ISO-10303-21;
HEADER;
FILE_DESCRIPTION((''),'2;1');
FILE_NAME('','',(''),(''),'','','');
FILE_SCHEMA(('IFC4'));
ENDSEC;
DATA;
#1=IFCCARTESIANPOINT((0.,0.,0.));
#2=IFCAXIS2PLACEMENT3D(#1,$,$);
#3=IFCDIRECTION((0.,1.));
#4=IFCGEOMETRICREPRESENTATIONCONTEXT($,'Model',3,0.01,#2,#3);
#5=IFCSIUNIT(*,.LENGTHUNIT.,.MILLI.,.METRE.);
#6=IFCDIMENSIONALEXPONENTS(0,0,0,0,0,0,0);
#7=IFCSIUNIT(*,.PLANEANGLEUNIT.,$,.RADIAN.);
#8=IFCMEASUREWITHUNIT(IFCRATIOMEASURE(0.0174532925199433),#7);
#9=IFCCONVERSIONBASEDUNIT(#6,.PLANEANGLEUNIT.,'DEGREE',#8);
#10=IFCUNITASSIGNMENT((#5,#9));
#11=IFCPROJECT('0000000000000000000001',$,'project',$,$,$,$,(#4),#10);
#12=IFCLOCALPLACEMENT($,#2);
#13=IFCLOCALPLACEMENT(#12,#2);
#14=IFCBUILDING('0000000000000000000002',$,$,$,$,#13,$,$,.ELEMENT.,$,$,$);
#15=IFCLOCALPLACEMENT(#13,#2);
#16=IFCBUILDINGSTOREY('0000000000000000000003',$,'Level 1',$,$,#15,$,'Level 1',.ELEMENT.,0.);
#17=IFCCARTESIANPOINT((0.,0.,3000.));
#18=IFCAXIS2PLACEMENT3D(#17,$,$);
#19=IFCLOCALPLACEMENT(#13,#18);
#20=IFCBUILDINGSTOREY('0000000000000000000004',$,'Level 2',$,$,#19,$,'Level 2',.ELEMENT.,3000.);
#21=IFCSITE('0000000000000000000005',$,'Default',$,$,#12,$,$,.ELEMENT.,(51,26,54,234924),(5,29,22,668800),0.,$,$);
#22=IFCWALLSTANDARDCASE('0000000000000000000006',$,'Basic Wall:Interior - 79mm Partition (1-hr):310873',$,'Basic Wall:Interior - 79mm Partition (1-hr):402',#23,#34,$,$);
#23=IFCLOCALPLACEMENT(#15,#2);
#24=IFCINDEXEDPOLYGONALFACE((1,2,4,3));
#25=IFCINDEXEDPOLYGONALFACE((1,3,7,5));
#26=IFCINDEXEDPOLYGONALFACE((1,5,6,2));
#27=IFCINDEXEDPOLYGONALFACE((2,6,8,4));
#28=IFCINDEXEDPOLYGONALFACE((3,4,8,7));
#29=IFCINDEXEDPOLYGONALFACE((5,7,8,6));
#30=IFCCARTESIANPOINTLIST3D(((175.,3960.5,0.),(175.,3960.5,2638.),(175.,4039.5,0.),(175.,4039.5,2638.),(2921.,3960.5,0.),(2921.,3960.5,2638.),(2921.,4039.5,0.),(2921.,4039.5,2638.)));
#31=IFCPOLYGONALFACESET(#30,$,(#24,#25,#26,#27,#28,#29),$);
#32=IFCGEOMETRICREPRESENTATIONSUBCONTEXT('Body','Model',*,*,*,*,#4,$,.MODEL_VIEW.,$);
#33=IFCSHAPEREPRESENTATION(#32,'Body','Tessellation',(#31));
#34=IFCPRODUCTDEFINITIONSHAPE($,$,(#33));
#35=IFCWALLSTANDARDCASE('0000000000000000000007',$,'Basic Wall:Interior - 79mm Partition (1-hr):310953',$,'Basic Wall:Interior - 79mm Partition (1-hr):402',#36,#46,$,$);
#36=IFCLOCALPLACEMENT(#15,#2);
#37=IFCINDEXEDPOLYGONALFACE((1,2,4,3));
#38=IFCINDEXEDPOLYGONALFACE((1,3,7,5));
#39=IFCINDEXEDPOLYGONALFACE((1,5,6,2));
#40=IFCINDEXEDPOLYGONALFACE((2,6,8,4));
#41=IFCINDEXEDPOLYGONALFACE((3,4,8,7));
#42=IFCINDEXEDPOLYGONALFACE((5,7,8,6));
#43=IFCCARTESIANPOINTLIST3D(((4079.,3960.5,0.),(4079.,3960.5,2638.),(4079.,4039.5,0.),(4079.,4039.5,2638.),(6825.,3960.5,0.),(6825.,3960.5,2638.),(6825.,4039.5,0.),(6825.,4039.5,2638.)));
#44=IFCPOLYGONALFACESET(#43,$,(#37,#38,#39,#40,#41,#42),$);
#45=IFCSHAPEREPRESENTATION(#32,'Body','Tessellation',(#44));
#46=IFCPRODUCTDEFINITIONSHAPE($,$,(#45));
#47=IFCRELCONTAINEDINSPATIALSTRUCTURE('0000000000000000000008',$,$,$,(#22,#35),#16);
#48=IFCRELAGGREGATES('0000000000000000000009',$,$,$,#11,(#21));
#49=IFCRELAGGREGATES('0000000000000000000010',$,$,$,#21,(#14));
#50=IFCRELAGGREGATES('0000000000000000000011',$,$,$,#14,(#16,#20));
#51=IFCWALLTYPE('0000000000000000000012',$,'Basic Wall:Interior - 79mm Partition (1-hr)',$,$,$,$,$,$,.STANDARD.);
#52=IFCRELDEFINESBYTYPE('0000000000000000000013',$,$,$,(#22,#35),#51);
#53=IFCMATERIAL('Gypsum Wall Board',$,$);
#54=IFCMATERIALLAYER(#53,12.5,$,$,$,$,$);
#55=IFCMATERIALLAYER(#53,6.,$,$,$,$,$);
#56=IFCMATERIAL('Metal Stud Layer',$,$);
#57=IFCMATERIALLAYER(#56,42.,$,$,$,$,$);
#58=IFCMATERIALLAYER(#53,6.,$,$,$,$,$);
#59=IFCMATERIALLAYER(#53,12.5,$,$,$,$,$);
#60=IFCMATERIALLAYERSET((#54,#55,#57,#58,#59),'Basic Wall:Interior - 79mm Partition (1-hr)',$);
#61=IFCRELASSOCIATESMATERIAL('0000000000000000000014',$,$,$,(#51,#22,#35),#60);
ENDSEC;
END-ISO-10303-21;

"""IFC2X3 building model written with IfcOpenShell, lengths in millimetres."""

from ifc_helpers import new_model, entity, si_unit, converted_unit, direction, frame, frame_2d, origin, place, context, subcontext, project, spatial, polyline, rectangle, extrude, clip, bounded_halfspace, material, layer, layer_set, layer_usage, type_object, element, save


model = new_model("IFC2X3")

# Units and contexts
model_context = context("Model", 3, precision=0.01, world=origin(), true_north=direction((0.0, 1.0)))
body_context = subcontext(model_context, "Body", "Model", "MODEL_VIEW")
ifc_project = project(units=[si_unit("LENGTHUNIT", "METRE", prefix="MILLI"), converted_unit("PLANEANGLEUNIT", "DEGREE", entity("IfcRatioMeasure", 0.0174532925199433), si_unit("PLANEANGLEUNIT", "RADIAN"), dimensions=[0, 0, 0, 0, 0, 0, 0])], contexts=[model_context])

# Site, building, storey
site_placement = place(None, origin())
site = spatial("IfcSite", under=ifc_project, at=site_placement, Name="Default", CompositionType="ELEMENT", RefLatitude=(51, 26, 54, 234924), RefLongitude=(5, 29, 22, 668800), RefElevation=0.0)
building_placement = place(site_placement, origin())
building = spatial("IfcBuilding", under=site, at=building_placement, CompositionType="ELEMENT")
storey_1_placement = place(building_placement, origin())
storey_1 = spatial("IfcBuildingStorey", under=building, at=storey_1_placement, Name="Level 1", LongName="Level 1", CompositionType="ELEMENT", Elevation=0.0)

# Shared definitions
ifc_material_1 = material(Name="Metal Stud Layer")
ifc_material_2 = material(Name="Gypsum Wall Board")

# Shared definitions
storey_2_placement = place(building_placement, frame((0.0, 0.0, 3000.0)))
storey_2 = spatial("IfcBuildingStorey", under=building, at=storey_2_placement, Name="Level 2", LongName="Level 2", CompositionType="ELEMENT", Elevation=3000.0)

# Walls
ifc_layer_1 = layer(ifc_material_2, 12.5)
ifc_layer_2 = layer(ifc_material_2, 6.0)
ifc_layer_3 = layer(ifc_material_1, 42.0)
ifc_layer_4 = layer(ifc_material_2, 6.0)
ifc_layer_5 = layer(ifc_material_2, 12.5)
ifc_layer_set_1 = layer_set([ifc_layer_1, ifc_layer_2, ifc_layer_3, ifc_layer_4, ifc_layer_5], Name="Basic Wall:Interior - 79mm Partition (1-hr)")
wall_type_1 = type_object("IfcWallType", Name="Basic Wall:Interior - 79mm Partition (1-hr)", PredefinedType="STANDARD", material=ifc_layer_set_1)
ifc_layer_usage_1 = layer_usage(ifc_layer_set_1, "AXIS2", "NEGATIVE", 39.5)
wall_1_placement = place(storey_1_placement, frame((2921.0, 4000.0, 0.0), z_axis=(0.0, 0.0, 1.0), x_axis=(-1.0, 0.0, 0.0)))
element("IfcWallStandardCase", 1, at=wall_1_placement, inside=storey_1, type_object=wall_type_1, material=ifc_layer_usage_1, Name="Basic Wall:Interior - 79mm Partition (1-hr):310873", ObjectType="Basic Wall:Interior - 79mm Partition (1-hr):402", context=body_context, shape_type="Clipping", body=[
    clip(extrude(rectangle(XDim=2746.0, YDim=79.0, at=frame_2d((1373.0, 0.0), x_axis=(-1.0, 0.0))), origin(), (0.0, 0.0, 1.0), 2638.0), bounded_halfspace(frame((0.0, -39.5, 2638.0), z_axis=(0.0, 0.0, -1.0), x_axis=(0.0, 1.0, 0.0)), True, frame((0.0, -39.5, 2638.0)), polyline([(0.0, 0.0), (2746.0, 0.0), (2746.0, 79.0), (0.0, 79.0), (0.0, 0.0)]))),
])
ifc_layer_usage_2 = layer_usage(ifc_layer_set_1, "AXIS2", "NEGATIVE", 39.5)
wall_2_placement = place(storey_1_placement, frame((4079.0, 4000.0, 0.0)))
element("IfcWallStandardCase", 2, at=wall_2_placement, inside=storey_1, type_object=wall_type_1, material=ifc_layer_usage_2, Name="Basic Wall:Interior - 79mm Partition (1-hr):310953", ObjectType="Basic Wall:Interior - 79mm Partition (1-hr):402", context=body_context, shape_type="Clipping", body=[
    clip(extrude(rectangle(XDim=2746.0, YDim=79.0, at=frame_2d((1373.0, 0.0), x_axis=(-1.0, 0.0))), origin(), (0.0, 0.0, 1.0), 2638.0), bounded_halfspace(frame((0.0, -39.5, 2638.0), z_axis=(0.0, 0.0, -1.0), x_axis=(0.0, -1.0, 0.0)), True, frame((0.0, -39.5, 2638.0)), polyline([(0.0, 0.0), (2746.0, 0.0), (2746.0, 79.0), (0.0, 79.0), (0.0, 0.0)]))),
])

save(model, "model.ifc")
